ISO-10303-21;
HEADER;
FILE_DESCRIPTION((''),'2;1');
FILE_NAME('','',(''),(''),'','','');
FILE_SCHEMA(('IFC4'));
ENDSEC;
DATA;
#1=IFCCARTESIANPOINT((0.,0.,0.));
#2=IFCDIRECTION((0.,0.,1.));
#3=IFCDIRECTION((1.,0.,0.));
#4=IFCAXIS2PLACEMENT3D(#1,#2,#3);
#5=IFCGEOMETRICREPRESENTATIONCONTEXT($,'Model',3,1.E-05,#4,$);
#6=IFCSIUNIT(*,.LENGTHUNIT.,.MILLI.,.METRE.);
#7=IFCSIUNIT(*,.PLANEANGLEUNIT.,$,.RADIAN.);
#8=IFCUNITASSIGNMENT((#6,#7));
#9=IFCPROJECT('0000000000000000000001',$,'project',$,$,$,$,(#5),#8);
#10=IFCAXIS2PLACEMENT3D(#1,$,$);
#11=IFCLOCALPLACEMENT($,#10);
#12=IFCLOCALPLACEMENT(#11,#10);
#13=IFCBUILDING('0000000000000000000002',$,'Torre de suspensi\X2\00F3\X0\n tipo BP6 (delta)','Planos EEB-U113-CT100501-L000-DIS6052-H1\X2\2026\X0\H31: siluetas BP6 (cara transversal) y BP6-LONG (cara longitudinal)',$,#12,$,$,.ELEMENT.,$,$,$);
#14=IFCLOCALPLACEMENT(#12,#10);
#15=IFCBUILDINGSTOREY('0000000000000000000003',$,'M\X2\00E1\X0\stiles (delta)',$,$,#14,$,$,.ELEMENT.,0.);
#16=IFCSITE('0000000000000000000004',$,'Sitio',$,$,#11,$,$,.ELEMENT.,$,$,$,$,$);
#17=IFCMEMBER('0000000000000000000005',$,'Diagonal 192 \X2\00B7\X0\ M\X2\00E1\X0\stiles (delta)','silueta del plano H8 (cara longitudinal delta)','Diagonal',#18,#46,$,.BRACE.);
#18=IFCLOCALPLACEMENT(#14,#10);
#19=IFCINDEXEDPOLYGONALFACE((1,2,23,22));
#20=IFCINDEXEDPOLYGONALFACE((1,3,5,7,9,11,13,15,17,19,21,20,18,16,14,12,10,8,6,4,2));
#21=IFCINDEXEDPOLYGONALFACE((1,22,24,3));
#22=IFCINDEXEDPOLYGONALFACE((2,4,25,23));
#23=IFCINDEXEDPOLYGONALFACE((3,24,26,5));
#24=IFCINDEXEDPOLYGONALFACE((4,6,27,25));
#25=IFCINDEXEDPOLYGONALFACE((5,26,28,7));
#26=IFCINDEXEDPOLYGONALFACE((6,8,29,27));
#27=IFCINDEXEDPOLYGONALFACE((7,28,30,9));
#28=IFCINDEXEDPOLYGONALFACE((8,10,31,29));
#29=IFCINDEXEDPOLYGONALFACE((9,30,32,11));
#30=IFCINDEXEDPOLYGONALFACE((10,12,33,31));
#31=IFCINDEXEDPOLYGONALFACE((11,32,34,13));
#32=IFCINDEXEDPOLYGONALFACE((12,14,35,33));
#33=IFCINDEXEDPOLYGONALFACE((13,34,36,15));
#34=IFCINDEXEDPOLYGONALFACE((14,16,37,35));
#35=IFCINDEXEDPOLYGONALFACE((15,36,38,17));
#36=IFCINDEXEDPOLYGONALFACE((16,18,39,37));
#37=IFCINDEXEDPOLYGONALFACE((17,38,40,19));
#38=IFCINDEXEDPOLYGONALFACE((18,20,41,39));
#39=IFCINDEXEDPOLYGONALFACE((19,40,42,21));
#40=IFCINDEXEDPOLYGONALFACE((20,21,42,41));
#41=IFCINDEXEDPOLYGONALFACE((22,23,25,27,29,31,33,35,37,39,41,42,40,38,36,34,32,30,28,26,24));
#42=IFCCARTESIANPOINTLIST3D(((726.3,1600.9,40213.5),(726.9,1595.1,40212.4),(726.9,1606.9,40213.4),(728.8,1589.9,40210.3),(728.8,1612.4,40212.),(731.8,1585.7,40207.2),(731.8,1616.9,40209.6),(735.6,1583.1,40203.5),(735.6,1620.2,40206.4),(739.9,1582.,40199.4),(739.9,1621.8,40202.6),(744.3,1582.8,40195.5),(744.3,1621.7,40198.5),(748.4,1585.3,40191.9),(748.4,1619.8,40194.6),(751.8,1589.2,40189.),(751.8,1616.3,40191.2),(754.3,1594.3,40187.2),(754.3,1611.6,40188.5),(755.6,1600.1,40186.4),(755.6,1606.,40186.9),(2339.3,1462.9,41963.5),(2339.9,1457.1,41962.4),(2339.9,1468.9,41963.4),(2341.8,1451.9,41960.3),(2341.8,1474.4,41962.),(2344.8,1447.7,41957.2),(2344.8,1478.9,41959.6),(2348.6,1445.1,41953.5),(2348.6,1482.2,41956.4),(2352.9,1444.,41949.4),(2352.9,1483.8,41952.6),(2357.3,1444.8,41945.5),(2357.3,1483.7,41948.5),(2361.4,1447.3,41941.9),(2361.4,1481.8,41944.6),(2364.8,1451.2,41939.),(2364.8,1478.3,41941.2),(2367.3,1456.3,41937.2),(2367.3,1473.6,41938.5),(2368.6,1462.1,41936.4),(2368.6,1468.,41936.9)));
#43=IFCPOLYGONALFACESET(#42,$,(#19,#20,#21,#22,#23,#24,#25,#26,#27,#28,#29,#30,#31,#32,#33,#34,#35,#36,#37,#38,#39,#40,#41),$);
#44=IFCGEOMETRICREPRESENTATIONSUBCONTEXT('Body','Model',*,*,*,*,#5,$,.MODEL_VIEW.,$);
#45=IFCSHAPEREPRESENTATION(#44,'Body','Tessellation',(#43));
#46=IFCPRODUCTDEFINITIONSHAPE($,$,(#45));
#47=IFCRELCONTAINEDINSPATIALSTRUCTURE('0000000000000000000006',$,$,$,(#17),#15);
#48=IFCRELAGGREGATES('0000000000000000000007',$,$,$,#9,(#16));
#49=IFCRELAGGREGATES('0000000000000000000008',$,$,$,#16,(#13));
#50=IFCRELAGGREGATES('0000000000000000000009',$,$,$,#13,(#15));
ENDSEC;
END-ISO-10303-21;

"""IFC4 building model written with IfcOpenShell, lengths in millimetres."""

from ifc_helpers import new_model, si_unit, frame, origin, origin_with_axes, place, context, subcontext, project, spatial, circle, extrude, element, save


model = new_model("IFC4")

# Units and contexts
model_context = context("Model", 3, precision=1e-05, world=origin_with_axes())
body_context = subcontext(model_context, "Body", "Model", "MODEL_VIEW")
ifc_project = project(units=[si_unit("LENGTHUNIT", "METRE", prefix="MILLI"), si_unit("PLANEANGLEUNIT", "RADIAN")], contexts=[model_context])

# Site, building, storey
site_placement = place(None, origin())
site = spatial("IfcSite", under=ifc_project, at=site_placement, Name="Sitio", CompositionType="ELEMENT")
building_placement = place(site_placement, origin())
building = spatial("IfcBuilding", under=site, at=building_placement, Name="Torre de suspensión tipo BP6 (delta)", Description="Planos EEB-U113-CT100501-L000-DIS6052-H1…H31: siluetas BP6 (cara transversal) y BP6-LONG (cara longitudinal)", CompositionType="ELEMENT")
storey_placement = place(building_placement, origin())
storey = spatial("IfcBuildingStorey", under=building, at=storey_placement, Name="Mástiles (delta)", CompositionType="ELEMENT", Elevation=0.0)

# Member
member_1_placement = place(storey_placement, frame((2354.0, 1464.0, 41950.0), z_axis=(-0.676602, 0.057887, -0.73407), x_axis=(-0.736348, -0.05319, 0.674509)))
element("IfcMember", 1, at=member_1_placement, inside=storey, Name="Diagonal 192 · Mástiles (delta)", Description="silueta del plano H8 (cara longitudinal delta)", ObjectType="Diagonal", PredefinedType="BRACE", context=body_context, shape_type="SweptSolid", body=[
    extrude(circle(Radius=20.0), None, (0.0, 0.0, 1.0), 2384.0),
])

save(model, "model.ifc")
